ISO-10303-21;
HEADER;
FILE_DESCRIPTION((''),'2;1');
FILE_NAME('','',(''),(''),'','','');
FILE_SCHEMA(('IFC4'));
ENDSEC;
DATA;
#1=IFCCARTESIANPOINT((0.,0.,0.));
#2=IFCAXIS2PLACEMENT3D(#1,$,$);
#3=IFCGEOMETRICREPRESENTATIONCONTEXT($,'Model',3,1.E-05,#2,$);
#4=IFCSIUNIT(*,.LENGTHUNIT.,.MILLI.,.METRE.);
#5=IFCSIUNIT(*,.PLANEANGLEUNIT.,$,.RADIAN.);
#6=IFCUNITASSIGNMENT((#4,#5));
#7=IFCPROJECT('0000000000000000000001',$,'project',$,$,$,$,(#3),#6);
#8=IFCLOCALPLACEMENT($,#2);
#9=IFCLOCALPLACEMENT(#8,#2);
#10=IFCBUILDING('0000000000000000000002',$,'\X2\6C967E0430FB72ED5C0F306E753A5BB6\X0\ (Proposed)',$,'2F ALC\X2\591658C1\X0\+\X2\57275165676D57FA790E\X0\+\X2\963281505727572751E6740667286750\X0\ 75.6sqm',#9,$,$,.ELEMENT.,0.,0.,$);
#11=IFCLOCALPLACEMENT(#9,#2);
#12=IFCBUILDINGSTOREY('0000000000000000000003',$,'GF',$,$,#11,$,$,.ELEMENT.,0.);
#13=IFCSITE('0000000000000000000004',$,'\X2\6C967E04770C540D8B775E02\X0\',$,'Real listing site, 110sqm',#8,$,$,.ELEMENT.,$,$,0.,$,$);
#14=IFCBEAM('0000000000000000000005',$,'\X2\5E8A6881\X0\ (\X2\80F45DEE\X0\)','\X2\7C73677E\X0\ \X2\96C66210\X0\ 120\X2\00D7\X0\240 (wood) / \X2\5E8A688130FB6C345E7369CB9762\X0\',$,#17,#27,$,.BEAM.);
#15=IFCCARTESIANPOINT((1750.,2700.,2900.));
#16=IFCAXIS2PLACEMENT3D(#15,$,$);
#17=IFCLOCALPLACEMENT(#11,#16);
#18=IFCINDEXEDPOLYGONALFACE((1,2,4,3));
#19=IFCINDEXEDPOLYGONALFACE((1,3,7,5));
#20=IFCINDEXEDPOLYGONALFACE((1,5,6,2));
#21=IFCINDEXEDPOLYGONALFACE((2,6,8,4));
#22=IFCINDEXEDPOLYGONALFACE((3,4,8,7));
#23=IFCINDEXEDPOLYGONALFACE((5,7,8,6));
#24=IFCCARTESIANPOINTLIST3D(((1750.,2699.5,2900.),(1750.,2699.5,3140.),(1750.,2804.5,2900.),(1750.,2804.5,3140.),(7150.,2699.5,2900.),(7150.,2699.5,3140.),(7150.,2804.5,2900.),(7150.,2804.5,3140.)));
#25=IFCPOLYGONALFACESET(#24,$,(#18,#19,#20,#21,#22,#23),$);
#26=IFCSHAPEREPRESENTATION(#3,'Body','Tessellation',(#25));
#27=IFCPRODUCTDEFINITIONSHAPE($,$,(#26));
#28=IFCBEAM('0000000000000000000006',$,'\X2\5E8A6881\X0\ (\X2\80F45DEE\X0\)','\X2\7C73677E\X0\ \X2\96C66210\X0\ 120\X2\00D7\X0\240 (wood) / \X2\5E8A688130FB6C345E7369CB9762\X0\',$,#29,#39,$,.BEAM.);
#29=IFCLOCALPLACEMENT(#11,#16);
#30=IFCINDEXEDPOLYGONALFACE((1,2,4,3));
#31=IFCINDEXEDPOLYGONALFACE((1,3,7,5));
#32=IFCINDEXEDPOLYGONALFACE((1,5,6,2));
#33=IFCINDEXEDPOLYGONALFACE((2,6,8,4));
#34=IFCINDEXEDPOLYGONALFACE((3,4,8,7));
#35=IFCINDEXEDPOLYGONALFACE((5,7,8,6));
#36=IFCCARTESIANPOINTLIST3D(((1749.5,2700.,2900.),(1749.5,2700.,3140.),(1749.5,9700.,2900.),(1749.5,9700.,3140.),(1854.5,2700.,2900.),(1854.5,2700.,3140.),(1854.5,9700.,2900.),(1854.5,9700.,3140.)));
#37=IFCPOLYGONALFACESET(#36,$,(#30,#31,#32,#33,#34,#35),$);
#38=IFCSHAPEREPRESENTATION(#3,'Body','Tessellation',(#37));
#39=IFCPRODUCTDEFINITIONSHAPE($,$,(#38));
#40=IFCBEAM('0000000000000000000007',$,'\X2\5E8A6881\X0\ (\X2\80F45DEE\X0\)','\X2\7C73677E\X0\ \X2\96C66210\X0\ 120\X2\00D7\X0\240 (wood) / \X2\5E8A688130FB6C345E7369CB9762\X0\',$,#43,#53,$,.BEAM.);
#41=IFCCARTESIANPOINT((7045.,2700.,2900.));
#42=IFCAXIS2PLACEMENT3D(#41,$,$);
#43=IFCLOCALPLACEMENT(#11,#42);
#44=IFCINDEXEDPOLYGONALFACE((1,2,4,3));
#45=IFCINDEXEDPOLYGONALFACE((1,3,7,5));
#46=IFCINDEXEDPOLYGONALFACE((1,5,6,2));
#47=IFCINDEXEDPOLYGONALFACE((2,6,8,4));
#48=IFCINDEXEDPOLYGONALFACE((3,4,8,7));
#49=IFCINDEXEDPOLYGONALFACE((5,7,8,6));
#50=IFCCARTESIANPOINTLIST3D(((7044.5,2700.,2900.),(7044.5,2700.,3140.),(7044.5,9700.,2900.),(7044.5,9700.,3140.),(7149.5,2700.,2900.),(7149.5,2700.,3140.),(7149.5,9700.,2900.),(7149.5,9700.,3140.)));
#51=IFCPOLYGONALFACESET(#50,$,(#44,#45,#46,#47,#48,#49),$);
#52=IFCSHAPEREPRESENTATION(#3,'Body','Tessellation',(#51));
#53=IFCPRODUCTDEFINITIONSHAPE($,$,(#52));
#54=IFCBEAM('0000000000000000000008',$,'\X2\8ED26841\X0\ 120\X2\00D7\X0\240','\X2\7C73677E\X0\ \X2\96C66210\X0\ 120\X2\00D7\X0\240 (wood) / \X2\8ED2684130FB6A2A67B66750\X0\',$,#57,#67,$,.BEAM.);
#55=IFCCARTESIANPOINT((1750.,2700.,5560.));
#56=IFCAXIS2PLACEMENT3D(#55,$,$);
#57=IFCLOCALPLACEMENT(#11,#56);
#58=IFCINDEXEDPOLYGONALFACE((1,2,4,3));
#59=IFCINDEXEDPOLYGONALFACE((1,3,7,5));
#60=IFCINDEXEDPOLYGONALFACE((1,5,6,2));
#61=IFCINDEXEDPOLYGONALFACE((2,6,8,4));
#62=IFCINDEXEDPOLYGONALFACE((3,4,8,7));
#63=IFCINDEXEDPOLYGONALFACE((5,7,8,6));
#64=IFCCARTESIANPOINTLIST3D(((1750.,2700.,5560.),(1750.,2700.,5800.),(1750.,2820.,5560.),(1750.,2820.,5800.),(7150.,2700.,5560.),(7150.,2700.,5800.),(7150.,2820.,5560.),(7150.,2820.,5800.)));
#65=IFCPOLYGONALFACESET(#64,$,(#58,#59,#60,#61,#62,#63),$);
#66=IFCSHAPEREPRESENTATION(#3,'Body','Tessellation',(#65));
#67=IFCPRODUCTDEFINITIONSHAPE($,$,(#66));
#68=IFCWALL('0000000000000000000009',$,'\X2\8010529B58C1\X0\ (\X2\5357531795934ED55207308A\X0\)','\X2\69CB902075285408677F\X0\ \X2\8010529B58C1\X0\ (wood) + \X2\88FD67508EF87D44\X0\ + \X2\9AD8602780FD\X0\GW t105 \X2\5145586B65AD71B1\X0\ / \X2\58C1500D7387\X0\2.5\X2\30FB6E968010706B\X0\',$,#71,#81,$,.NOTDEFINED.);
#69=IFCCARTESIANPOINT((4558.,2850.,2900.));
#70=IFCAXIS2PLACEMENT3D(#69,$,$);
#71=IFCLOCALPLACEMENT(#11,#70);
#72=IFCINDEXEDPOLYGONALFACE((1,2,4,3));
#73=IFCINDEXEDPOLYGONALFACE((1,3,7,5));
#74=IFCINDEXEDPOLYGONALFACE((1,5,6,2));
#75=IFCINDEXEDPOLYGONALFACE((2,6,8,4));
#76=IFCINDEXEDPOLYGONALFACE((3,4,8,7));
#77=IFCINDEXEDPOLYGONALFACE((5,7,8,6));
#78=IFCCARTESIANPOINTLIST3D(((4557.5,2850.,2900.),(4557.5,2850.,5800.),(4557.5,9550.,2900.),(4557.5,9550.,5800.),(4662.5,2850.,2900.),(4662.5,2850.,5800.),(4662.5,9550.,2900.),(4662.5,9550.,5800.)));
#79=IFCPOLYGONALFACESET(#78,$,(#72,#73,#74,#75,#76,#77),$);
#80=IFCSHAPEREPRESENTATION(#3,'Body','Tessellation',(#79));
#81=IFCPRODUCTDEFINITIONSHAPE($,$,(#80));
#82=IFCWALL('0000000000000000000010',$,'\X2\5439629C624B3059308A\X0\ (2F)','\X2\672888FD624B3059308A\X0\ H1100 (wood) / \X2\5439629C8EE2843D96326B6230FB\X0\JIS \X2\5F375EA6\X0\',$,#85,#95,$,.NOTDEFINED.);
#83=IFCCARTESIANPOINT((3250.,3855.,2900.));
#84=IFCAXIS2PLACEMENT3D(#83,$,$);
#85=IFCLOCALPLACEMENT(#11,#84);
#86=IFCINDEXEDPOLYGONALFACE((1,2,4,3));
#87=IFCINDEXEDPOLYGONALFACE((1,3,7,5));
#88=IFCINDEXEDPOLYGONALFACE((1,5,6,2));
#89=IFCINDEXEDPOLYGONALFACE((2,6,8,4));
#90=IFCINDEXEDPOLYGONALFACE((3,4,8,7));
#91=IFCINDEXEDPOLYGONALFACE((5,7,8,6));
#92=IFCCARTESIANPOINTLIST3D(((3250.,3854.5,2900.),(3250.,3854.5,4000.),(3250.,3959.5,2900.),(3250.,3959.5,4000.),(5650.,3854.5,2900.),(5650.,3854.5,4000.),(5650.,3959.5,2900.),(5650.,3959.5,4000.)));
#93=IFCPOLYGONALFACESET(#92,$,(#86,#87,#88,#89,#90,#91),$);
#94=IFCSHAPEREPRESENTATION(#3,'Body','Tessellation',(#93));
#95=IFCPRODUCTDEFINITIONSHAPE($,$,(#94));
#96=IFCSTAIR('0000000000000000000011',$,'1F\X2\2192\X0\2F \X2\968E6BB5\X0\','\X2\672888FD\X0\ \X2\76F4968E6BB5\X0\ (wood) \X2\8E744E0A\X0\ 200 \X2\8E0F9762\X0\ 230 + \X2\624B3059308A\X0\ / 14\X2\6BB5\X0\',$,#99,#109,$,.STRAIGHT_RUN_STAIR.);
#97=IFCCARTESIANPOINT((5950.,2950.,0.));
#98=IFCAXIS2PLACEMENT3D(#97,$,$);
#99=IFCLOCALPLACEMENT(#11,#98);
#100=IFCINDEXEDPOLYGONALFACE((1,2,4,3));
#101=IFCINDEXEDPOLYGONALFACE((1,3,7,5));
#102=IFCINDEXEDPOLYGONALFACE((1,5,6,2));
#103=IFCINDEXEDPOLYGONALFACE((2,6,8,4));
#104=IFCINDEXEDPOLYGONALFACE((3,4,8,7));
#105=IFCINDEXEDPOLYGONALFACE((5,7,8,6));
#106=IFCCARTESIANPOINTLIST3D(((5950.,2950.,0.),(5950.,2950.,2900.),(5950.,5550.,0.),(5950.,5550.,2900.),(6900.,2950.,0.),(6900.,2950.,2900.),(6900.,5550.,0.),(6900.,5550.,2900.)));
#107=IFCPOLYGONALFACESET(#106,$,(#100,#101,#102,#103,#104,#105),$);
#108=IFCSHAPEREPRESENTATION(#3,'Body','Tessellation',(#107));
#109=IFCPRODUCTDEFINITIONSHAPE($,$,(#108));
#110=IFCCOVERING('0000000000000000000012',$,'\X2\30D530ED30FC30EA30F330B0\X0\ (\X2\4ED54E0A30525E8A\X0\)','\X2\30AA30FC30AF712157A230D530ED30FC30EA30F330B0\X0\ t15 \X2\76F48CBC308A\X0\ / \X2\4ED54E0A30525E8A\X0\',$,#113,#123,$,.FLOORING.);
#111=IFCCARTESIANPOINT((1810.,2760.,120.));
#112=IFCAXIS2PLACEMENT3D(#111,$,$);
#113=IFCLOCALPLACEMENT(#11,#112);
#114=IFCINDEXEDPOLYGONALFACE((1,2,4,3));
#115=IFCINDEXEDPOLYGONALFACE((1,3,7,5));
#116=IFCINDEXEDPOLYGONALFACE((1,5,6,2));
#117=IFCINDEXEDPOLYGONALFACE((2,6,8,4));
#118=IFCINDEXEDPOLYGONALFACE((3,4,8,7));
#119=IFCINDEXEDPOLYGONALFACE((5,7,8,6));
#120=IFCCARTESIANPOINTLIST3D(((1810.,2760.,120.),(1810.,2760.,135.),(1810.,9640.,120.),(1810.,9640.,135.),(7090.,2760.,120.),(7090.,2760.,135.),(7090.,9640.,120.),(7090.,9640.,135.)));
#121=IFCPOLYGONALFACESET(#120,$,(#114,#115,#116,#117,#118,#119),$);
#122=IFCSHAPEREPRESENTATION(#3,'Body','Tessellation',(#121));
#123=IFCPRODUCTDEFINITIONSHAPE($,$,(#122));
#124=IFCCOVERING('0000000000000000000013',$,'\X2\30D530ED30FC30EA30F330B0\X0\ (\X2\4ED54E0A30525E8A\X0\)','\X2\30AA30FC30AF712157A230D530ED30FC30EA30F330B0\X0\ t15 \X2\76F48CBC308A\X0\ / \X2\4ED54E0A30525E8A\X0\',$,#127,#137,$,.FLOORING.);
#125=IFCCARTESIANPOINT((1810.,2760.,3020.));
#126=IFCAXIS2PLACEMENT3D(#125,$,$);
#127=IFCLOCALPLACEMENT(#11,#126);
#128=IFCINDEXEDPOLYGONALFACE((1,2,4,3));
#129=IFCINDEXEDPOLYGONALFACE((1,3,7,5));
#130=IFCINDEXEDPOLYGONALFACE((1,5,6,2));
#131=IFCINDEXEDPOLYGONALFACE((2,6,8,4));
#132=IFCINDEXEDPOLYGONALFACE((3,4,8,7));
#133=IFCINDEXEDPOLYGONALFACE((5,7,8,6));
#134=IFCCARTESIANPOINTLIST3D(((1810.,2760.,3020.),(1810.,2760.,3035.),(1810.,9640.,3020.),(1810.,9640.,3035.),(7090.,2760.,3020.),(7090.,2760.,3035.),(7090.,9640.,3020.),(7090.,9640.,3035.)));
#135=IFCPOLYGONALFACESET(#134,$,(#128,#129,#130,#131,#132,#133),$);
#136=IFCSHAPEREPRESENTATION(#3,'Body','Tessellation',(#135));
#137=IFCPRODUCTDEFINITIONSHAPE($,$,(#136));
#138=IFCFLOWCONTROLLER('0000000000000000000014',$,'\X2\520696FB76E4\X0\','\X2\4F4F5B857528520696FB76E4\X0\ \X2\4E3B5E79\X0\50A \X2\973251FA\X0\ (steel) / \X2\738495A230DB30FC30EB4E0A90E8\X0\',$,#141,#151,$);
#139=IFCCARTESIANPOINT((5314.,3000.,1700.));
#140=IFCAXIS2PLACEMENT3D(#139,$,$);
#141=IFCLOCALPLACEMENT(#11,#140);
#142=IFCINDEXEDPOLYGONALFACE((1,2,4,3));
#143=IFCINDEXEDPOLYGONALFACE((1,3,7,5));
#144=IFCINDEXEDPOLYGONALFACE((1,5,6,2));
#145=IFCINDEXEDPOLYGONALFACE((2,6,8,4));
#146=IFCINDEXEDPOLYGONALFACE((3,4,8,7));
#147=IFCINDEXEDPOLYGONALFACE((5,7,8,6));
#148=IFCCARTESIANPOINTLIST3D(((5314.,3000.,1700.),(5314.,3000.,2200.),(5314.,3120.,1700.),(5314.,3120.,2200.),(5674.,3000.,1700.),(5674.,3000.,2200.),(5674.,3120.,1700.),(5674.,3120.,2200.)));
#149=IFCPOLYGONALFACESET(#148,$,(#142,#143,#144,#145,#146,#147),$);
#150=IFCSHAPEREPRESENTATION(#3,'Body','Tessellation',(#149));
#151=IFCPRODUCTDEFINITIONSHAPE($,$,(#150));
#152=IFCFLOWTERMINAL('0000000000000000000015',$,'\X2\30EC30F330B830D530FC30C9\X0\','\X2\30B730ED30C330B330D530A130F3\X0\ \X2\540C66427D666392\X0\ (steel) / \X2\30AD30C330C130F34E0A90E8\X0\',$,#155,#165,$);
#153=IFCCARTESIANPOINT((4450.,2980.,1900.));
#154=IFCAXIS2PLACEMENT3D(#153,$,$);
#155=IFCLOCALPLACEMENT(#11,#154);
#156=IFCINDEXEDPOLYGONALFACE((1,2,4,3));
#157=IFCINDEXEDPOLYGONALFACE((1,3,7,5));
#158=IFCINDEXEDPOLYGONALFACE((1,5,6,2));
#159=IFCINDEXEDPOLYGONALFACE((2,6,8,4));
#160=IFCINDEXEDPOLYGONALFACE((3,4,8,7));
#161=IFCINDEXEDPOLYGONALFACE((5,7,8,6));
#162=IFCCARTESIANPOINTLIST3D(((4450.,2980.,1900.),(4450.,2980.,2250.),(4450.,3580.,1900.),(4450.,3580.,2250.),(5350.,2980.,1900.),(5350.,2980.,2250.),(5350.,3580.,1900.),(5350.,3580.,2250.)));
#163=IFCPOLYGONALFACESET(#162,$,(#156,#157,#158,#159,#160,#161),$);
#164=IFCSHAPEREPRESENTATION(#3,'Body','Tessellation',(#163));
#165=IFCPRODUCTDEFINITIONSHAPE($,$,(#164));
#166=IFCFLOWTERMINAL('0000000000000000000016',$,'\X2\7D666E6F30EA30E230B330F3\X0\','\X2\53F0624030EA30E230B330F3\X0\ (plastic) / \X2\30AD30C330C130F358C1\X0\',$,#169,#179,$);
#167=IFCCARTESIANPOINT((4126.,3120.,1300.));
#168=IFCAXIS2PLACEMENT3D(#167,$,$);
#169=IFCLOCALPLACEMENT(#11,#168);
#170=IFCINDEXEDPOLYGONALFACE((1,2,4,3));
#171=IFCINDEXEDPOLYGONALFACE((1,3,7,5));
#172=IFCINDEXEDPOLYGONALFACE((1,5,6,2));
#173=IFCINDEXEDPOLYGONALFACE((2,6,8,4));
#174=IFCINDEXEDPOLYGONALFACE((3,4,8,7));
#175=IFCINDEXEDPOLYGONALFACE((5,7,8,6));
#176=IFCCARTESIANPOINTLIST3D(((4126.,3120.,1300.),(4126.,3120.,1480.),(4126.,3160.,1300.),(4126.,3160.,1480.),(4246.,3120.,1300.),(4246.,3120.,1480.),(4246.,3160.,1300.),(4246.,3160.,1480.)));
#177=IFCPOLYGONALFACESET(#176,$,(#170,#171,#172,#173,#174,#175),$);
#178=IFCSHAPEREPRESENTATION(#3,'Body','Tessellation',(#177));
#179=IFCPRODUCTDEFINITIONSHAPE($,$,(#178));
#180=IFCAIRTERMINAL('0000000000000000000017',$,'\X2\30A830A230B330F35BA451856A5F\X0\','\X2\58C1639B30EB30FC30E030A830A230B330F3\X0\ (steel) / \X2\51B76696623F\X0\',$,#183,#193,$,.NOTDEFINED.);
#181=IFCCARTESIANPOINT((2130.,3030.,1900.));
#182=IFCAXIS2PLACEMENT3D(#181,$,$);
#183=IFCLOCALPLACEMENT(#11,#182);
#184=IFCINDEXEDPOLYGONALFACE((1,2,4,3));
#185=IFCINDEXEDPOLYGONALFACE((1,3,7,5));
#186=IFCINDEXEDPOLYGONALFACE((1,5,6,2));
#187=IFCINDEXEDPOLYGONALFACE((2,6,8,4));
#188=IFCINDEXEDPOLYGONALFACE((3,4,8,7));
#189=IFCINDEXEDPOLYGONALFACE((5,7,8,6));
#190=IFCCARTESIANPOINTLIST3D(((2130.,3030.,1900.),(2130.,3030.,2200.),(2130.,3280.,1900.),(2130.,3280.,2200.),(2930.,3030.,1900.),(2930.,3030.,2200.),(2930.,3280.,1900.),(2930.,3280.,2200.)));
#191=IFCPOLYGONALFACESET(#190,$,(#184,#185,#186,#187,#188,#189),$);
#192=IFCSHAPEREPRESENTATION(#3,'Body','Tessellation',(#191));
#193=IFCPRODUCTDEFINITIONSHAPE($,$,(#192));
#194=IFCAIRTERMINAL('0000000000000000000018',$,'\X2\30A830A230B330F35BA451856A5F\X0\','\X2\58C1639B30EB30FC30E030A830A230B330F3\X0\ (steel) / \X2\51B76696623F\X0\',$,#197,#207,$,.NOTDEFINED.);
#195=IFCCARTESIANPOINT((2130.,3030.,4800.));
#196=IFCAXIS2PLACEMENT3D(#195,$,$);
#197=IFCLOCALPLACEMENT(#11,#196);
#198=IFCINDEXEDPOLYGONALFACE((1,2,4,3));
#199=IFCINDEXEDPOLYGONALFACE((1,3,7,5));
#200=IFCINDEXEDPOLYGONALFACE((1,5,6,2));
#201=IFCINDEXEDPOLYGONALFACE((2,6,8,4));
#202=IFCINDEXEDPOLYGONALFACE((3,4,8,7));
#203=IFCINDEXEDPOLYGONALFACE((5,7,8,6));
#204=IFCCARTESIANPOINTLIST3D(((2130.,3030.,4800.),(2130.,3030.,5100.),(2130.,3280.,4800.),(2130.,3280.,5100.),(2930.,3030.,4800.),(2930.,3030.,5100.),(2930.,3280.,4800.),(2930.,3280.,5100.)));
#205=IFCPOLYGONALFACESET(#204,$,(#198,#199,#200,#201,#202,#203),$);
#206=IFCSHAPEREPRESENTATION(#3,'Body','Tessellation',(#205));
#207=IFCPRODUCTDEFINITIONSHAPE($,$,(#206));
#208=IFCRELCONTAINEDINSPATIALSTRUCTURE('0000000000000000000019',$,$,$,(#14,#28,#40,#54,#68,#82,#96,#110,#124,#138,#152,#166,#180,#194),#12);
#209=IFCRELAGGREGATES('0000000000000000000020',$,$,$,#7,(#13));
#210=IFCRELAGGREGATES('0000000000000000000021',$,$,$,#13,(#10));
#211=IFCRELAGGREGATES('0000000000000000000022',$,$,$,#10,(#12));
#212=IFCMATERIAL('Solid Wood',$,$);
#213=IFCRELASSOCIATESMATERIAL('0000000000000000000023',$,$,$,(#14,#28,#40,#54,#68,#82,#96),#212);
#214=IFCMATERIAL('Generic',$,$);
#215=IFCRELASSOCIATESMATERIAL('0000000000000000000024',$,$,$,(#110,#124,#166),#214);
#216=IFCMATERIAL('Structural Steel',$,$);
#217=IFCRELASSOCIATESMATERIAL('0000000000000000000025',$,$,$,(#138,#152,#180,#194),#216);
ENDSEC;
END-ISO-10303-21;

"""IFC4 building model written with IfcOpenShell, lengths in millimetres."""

from ifc_helpers import new_model, si_unit, frame, frame_2d, origin, place, context, project, spatial, rectangle, extrude, material, element, save


model = new_model("IFC4")

# Units and contexts
model_context = context("Model", 3, precision=1e-05, world=origin())
ifc_project = project(units=[si_unit("LENGTHUNIT", "METRE", prefix="MILLI"), si_unit("PLANEANGLEUNIT", "RADIAN")], contexts=[model_context])

# Site, building, storey
site_placement = place(None, origin())
site = spatial("IfcSite", under=ifc_project, at=site_placement, Name="沖縄県名護市", ObjectType="Real listing site, 110sqm", CompositionType="ELEMENT", RefElevation=0.0)
building_placement = place(site_placement, origin())
building = spatial("IfcBuilding", under=site, at=building_placement, Name="沖縄・狭小の町家 (Proposed)", ObjectType="2F ALC外壁+圧入杭基礎+防腐圧圧処理木材 75.6sqm", CompositionType="ELEMENT", ElevationOfRefHeight=0.0, ElevationOfTerrain=0.0)
storey_placement = place(building_placement, origin())
storey = spatial("IfcBuildingStorey", under=building, at=storey_placement, Name="GF", CompositionType="ELEMENT", Elevation=0.0)

# Shared definitions
ifc_material_1 = material(Name="Solid Wood")

# Beams
beam_1_placement = place(storey_placement, frame((1750.0, 2700.0, 2900.0)))
element("IfcBeam", 1, at=beam_1_placement, inside=storey, material=ifc_material_1, Name="床梁 (胴差)", Description="米松 集成 120×240 (wood) / 床梁・水平構面", PredefinedType="BEAM", context=model_context, shape_type="SweptSolid", body=[
    extrude(rectangle(XDim=5400.0, YDim=105.0, at=frame_2d((2700.0, 52.0))), frame((1750.0, 2700.0, 2900.0)), (0.0, 0.0, 1.0), 240.0),
])
beam_2_placement = place(storey_placement, frame((1750.0, 2700.0, 2900.0)))
element("IfcBeam", 2, at=beam_2_placement, inside=storey, material=ifc_material_1, Name="床梁 (胴差)", Description="米松 集成 120×240 (wood) / 床梁・水平構面", PredefinedType="BEAM", context=model_context, shape_type="SweptSolid", body=[
    extrude(rectangle(XDim=105.0, YDim=7000.0, at=frame_2d((52.0, 3500.0))), frame((1750.0, 2700.0, 2900.0)), (0.0, 0.0, 1.0), 240.0),
])
beam_3_placement = place(storey_placement, frame((7045.0, 2700.0, 2900.0)))
element("IfcBeam", 3, at=beam_3_placement, inside=storey, material=ifc_material_1, Name="床梁 (胴差)", Description="米松 集成 120×240 (wood) / 床梁・水平構面", PredefinedType="BEAM", context=model_context, shape_type="SweptSolid", body=[
    extrude(rectangle(XDim=105.0, YDim=7000.0, at=frame_2d((52.0, 3500.0))), frame((7045.0, 2700.0, 2900.0)), (0.0, 0.0, 1.0), 240.0),
])
beam_4_placement = place(storey_placement, frame((1750.0, 2700.0, 5560.0)))
element("IfcBeam", 4, at=beam_4_placement, inside=storey, material=ifc_material_1, Name="軒桁 120×240", Description="米松 集成 120×240 (wood) / 軒桁・横架材", PredefinedType="BEAM", context=model_context, shape_type="SweptSolid", body=[
    extrude(rectangle(XDim=5400.0, YDim=120.0, at=frame_2d((2700.0, 60.0))), frame((1750.0, 2700.0, 5560.0)), (0.0, 0.0, 1.0), 240.0),
])

# Walls
wall_1_placement = place(storey_placement, frame((4558.0, 2850.0, 2900.0)))
element("IfcWall", 5, at=wall_1_placement, inside=storey, material=ifc_material_1, Name="耐力壁 (南北間仕切り)", Description="構造用合板 耐力壁 (wood) + 製材軸組 + 高性能GW t105 充填断熱 / 壁倍率2.5・準耐火", PredefinedType="NOTDEFINED", context=model_context, shape_type="SweptSolid", body=[
    extrude(rectangle(XDim=105.0, YDim=6700.0, at=frame_2d((52.0, 3350.0))), frame((4558.0, 2850.0, 2900.0)), (0.0, 0.0, 1.0), 2900.0),
])
wall_2_placement = place(storey_placement, frame((3250.0, 3855.0, 2900.0)))
element("IfcWall", 6, at=wall_2_placement, inside=storey, material=ifc_material_1, Name="吹抜手すり (2F)", Description="木製手すり H1100 (wood) / 吹抜転落防止・JIS 強度", PredefinedType="NOTDEFINED", context=model_context, shape_type="SweptSolid", body=[
    extrude(rectangle(XDim=2400.0, YDim=105.0, at=frame_2d((1200.0, 52.0))), frame((3250.0, 3855.0, 2900.0)), (0.0, 0.0, 1.0), 1100.0),
])

# Stair
stair_placement = place(storey_placement, frame((5950.0, 2950.0, 0.0)))
element("IfcStair", 7, at=stair_placement, inside=storey, material=ifc_material_1, Name="1F→2F 階段", Description="木製 直階段 (wood) 蹴上 200 踏面 230 + 手すり / 14段", PredefinedType="STRAIGHT_RUN_STAIR", context=model_context, shape_type="SweptSolid", body=[
    extrude(rectangle(XDim=950.0, YDim=2600.0, at=frame_2d((475.0, 1300.0))), frame((5950.0, 2950.0, 0.0)), (0.0, 0.0, 1.0), 2900.0),
])

# Coverings
ifc_material_2 = material(Name="Generic")
covering_1_placement = place(storey_placement, frame((1810.0, 2760.0, 120.0)))
element("IfcCovering", 8, at=covering_1_placement, inside=storey, material=ifc_material_2, Name="フローリング (仕上げ床)", Description="オーク無垢フローリング t15 直貼り / 仕上げ床", PredefinedType="FLOORING", context=model_context, shape_type="SweptSolid", body=[
    extrude(rectangle(XDim=5280.0, YDim=6880.0, at=frame_2d((2640.0, 3440.0))), frame((1810.0, 2760.0, 120.0)), (0.0, 0.0, 1.0), 15.0),
])
covering_2_placement = place(storey_placement, frame((1810.0, 2760.0, 3020.0)))
element("IfcCovering", 9, at=covering_2_placement, inside=storey, material=ifc_material_2, Name="フローリング (仕上げ床)", Description="オーク無垢フローリング t15 直貼り / 仕上げ床", PredefinedType="FLOORING", context=model_context, shape_type="SweptSolid", body=[
    extrude(rectangle(XDim=5280.0, YDim=6880.0, at=frame_2d((2640.0, 3440.0))), frame((1810.0, 2760.0, 3020.0)), (0.0, 0.0, 1.0), 15.0),
])

# Flow controller
ifc_material_3 = material(Name="Structural Steel")
flow_controller_placement = place(storey_placement, frame((5314.0, 3000.0, 1700.0)))
element("IfcFlowController", 10, at=flow_controller_placement, inside=storey, material=ifc_material_3, Name="分電盤", Description="住宅用分電盤 主幹50A 露出 (steel) / 玄関ホール上部", context=model_context, shape_type="SweptSolid", body=[
    extrude(rectangle(XDim=360.0, YDim=120.0, at=frame_2d((180.0, 60.0))), frame((5314.0, 3000.0, 1700.0)), (0.0, 0.0, 1.0), 500.0),
])

# Flow terminals
flow_terminal_1_placement = place(storey_placement, frame((4450.0, 2980.0, 1900.0)))
element("IfcFlowTerminal", 11, at=flow_terminal_1_placement, inside=storey, material=ifc_material_3, Name="レンジフード", Description="シロッコファン 同時給排 (steel) / キッチン上部", context=model_context, shape_type="SweptSolid", body=[
    extrude(rectangle(XDim=900.0, YDim=600.0, at=frame_2d((450.0, 300.0))), frame((4450.0, 2980.0, 1900.0)), (0.0, 0.0, 1.0), 350.0),
])
flow_terminal_2_placement = place(storey_placement, frame((4126.0, 3120.0, 1300.0)))
element("IfcFlowTerminal", 12, at=flow_terminal_2_placement, inside=storey, material=ifc_material_2, Name="給湯リモコン", Description="台所リモコン (plastic) / キッチン壁", context=model_context, shape_type="SweptSolid", body=[
    extrude(rectangle(XDim=120.0, YDim=40.0, at=frame_2d((60.0, 20.0))), frame((4126.0, 3120.0, 1300.0)), (0.0, 0.0, 1.0), 180.0),
])

# Air terminals
air_terminal_1_placement = place(storey_placement, frame((2130.0, 3030.0, 1900.0)))
element("IfcAirTerminal", 13, at=air_terminal_1_placement, inside=storey, material=ifc_material_3, Name="エアコン室内機", Description="壁掛ルームエアコン (steel) / 冷暖房", PredefinedType="NOTDEFINED", context=model_context, shape_type="SweptSolid", body=[
    extrude(rectangle(XDim=800.0, YDim=250.0, at=frame_2d((400.0, 125.0))), frame((2130.0, 3030.0, 1900.0)), (0.0, 0.0, 1.0), 300.0),
])
air_terminal_2_placement = place(storey_placement, frame((2130.0, 3030.0, 4800.0)))
element("IfcAirTerminal", 14, at=air_terminal_2_placement, inside=storey, material=ifc_material_3, Name="エアコン室内機", Description="壁掛ルームエアコン (steel) / 冷暖房", PredefinedType="NOTDEFINED", context=model_context, shape_type="SweptSolid", body=[
    extrude(rectangle(XDim=800.0, YDim=250.0, at=frame_2d((400.0, 125.0))), frame((2130.0, 3030.0, 4800.0)), (0.0, 0.0, 1.0), 300.0),
])

save(model, "model.ifc")
